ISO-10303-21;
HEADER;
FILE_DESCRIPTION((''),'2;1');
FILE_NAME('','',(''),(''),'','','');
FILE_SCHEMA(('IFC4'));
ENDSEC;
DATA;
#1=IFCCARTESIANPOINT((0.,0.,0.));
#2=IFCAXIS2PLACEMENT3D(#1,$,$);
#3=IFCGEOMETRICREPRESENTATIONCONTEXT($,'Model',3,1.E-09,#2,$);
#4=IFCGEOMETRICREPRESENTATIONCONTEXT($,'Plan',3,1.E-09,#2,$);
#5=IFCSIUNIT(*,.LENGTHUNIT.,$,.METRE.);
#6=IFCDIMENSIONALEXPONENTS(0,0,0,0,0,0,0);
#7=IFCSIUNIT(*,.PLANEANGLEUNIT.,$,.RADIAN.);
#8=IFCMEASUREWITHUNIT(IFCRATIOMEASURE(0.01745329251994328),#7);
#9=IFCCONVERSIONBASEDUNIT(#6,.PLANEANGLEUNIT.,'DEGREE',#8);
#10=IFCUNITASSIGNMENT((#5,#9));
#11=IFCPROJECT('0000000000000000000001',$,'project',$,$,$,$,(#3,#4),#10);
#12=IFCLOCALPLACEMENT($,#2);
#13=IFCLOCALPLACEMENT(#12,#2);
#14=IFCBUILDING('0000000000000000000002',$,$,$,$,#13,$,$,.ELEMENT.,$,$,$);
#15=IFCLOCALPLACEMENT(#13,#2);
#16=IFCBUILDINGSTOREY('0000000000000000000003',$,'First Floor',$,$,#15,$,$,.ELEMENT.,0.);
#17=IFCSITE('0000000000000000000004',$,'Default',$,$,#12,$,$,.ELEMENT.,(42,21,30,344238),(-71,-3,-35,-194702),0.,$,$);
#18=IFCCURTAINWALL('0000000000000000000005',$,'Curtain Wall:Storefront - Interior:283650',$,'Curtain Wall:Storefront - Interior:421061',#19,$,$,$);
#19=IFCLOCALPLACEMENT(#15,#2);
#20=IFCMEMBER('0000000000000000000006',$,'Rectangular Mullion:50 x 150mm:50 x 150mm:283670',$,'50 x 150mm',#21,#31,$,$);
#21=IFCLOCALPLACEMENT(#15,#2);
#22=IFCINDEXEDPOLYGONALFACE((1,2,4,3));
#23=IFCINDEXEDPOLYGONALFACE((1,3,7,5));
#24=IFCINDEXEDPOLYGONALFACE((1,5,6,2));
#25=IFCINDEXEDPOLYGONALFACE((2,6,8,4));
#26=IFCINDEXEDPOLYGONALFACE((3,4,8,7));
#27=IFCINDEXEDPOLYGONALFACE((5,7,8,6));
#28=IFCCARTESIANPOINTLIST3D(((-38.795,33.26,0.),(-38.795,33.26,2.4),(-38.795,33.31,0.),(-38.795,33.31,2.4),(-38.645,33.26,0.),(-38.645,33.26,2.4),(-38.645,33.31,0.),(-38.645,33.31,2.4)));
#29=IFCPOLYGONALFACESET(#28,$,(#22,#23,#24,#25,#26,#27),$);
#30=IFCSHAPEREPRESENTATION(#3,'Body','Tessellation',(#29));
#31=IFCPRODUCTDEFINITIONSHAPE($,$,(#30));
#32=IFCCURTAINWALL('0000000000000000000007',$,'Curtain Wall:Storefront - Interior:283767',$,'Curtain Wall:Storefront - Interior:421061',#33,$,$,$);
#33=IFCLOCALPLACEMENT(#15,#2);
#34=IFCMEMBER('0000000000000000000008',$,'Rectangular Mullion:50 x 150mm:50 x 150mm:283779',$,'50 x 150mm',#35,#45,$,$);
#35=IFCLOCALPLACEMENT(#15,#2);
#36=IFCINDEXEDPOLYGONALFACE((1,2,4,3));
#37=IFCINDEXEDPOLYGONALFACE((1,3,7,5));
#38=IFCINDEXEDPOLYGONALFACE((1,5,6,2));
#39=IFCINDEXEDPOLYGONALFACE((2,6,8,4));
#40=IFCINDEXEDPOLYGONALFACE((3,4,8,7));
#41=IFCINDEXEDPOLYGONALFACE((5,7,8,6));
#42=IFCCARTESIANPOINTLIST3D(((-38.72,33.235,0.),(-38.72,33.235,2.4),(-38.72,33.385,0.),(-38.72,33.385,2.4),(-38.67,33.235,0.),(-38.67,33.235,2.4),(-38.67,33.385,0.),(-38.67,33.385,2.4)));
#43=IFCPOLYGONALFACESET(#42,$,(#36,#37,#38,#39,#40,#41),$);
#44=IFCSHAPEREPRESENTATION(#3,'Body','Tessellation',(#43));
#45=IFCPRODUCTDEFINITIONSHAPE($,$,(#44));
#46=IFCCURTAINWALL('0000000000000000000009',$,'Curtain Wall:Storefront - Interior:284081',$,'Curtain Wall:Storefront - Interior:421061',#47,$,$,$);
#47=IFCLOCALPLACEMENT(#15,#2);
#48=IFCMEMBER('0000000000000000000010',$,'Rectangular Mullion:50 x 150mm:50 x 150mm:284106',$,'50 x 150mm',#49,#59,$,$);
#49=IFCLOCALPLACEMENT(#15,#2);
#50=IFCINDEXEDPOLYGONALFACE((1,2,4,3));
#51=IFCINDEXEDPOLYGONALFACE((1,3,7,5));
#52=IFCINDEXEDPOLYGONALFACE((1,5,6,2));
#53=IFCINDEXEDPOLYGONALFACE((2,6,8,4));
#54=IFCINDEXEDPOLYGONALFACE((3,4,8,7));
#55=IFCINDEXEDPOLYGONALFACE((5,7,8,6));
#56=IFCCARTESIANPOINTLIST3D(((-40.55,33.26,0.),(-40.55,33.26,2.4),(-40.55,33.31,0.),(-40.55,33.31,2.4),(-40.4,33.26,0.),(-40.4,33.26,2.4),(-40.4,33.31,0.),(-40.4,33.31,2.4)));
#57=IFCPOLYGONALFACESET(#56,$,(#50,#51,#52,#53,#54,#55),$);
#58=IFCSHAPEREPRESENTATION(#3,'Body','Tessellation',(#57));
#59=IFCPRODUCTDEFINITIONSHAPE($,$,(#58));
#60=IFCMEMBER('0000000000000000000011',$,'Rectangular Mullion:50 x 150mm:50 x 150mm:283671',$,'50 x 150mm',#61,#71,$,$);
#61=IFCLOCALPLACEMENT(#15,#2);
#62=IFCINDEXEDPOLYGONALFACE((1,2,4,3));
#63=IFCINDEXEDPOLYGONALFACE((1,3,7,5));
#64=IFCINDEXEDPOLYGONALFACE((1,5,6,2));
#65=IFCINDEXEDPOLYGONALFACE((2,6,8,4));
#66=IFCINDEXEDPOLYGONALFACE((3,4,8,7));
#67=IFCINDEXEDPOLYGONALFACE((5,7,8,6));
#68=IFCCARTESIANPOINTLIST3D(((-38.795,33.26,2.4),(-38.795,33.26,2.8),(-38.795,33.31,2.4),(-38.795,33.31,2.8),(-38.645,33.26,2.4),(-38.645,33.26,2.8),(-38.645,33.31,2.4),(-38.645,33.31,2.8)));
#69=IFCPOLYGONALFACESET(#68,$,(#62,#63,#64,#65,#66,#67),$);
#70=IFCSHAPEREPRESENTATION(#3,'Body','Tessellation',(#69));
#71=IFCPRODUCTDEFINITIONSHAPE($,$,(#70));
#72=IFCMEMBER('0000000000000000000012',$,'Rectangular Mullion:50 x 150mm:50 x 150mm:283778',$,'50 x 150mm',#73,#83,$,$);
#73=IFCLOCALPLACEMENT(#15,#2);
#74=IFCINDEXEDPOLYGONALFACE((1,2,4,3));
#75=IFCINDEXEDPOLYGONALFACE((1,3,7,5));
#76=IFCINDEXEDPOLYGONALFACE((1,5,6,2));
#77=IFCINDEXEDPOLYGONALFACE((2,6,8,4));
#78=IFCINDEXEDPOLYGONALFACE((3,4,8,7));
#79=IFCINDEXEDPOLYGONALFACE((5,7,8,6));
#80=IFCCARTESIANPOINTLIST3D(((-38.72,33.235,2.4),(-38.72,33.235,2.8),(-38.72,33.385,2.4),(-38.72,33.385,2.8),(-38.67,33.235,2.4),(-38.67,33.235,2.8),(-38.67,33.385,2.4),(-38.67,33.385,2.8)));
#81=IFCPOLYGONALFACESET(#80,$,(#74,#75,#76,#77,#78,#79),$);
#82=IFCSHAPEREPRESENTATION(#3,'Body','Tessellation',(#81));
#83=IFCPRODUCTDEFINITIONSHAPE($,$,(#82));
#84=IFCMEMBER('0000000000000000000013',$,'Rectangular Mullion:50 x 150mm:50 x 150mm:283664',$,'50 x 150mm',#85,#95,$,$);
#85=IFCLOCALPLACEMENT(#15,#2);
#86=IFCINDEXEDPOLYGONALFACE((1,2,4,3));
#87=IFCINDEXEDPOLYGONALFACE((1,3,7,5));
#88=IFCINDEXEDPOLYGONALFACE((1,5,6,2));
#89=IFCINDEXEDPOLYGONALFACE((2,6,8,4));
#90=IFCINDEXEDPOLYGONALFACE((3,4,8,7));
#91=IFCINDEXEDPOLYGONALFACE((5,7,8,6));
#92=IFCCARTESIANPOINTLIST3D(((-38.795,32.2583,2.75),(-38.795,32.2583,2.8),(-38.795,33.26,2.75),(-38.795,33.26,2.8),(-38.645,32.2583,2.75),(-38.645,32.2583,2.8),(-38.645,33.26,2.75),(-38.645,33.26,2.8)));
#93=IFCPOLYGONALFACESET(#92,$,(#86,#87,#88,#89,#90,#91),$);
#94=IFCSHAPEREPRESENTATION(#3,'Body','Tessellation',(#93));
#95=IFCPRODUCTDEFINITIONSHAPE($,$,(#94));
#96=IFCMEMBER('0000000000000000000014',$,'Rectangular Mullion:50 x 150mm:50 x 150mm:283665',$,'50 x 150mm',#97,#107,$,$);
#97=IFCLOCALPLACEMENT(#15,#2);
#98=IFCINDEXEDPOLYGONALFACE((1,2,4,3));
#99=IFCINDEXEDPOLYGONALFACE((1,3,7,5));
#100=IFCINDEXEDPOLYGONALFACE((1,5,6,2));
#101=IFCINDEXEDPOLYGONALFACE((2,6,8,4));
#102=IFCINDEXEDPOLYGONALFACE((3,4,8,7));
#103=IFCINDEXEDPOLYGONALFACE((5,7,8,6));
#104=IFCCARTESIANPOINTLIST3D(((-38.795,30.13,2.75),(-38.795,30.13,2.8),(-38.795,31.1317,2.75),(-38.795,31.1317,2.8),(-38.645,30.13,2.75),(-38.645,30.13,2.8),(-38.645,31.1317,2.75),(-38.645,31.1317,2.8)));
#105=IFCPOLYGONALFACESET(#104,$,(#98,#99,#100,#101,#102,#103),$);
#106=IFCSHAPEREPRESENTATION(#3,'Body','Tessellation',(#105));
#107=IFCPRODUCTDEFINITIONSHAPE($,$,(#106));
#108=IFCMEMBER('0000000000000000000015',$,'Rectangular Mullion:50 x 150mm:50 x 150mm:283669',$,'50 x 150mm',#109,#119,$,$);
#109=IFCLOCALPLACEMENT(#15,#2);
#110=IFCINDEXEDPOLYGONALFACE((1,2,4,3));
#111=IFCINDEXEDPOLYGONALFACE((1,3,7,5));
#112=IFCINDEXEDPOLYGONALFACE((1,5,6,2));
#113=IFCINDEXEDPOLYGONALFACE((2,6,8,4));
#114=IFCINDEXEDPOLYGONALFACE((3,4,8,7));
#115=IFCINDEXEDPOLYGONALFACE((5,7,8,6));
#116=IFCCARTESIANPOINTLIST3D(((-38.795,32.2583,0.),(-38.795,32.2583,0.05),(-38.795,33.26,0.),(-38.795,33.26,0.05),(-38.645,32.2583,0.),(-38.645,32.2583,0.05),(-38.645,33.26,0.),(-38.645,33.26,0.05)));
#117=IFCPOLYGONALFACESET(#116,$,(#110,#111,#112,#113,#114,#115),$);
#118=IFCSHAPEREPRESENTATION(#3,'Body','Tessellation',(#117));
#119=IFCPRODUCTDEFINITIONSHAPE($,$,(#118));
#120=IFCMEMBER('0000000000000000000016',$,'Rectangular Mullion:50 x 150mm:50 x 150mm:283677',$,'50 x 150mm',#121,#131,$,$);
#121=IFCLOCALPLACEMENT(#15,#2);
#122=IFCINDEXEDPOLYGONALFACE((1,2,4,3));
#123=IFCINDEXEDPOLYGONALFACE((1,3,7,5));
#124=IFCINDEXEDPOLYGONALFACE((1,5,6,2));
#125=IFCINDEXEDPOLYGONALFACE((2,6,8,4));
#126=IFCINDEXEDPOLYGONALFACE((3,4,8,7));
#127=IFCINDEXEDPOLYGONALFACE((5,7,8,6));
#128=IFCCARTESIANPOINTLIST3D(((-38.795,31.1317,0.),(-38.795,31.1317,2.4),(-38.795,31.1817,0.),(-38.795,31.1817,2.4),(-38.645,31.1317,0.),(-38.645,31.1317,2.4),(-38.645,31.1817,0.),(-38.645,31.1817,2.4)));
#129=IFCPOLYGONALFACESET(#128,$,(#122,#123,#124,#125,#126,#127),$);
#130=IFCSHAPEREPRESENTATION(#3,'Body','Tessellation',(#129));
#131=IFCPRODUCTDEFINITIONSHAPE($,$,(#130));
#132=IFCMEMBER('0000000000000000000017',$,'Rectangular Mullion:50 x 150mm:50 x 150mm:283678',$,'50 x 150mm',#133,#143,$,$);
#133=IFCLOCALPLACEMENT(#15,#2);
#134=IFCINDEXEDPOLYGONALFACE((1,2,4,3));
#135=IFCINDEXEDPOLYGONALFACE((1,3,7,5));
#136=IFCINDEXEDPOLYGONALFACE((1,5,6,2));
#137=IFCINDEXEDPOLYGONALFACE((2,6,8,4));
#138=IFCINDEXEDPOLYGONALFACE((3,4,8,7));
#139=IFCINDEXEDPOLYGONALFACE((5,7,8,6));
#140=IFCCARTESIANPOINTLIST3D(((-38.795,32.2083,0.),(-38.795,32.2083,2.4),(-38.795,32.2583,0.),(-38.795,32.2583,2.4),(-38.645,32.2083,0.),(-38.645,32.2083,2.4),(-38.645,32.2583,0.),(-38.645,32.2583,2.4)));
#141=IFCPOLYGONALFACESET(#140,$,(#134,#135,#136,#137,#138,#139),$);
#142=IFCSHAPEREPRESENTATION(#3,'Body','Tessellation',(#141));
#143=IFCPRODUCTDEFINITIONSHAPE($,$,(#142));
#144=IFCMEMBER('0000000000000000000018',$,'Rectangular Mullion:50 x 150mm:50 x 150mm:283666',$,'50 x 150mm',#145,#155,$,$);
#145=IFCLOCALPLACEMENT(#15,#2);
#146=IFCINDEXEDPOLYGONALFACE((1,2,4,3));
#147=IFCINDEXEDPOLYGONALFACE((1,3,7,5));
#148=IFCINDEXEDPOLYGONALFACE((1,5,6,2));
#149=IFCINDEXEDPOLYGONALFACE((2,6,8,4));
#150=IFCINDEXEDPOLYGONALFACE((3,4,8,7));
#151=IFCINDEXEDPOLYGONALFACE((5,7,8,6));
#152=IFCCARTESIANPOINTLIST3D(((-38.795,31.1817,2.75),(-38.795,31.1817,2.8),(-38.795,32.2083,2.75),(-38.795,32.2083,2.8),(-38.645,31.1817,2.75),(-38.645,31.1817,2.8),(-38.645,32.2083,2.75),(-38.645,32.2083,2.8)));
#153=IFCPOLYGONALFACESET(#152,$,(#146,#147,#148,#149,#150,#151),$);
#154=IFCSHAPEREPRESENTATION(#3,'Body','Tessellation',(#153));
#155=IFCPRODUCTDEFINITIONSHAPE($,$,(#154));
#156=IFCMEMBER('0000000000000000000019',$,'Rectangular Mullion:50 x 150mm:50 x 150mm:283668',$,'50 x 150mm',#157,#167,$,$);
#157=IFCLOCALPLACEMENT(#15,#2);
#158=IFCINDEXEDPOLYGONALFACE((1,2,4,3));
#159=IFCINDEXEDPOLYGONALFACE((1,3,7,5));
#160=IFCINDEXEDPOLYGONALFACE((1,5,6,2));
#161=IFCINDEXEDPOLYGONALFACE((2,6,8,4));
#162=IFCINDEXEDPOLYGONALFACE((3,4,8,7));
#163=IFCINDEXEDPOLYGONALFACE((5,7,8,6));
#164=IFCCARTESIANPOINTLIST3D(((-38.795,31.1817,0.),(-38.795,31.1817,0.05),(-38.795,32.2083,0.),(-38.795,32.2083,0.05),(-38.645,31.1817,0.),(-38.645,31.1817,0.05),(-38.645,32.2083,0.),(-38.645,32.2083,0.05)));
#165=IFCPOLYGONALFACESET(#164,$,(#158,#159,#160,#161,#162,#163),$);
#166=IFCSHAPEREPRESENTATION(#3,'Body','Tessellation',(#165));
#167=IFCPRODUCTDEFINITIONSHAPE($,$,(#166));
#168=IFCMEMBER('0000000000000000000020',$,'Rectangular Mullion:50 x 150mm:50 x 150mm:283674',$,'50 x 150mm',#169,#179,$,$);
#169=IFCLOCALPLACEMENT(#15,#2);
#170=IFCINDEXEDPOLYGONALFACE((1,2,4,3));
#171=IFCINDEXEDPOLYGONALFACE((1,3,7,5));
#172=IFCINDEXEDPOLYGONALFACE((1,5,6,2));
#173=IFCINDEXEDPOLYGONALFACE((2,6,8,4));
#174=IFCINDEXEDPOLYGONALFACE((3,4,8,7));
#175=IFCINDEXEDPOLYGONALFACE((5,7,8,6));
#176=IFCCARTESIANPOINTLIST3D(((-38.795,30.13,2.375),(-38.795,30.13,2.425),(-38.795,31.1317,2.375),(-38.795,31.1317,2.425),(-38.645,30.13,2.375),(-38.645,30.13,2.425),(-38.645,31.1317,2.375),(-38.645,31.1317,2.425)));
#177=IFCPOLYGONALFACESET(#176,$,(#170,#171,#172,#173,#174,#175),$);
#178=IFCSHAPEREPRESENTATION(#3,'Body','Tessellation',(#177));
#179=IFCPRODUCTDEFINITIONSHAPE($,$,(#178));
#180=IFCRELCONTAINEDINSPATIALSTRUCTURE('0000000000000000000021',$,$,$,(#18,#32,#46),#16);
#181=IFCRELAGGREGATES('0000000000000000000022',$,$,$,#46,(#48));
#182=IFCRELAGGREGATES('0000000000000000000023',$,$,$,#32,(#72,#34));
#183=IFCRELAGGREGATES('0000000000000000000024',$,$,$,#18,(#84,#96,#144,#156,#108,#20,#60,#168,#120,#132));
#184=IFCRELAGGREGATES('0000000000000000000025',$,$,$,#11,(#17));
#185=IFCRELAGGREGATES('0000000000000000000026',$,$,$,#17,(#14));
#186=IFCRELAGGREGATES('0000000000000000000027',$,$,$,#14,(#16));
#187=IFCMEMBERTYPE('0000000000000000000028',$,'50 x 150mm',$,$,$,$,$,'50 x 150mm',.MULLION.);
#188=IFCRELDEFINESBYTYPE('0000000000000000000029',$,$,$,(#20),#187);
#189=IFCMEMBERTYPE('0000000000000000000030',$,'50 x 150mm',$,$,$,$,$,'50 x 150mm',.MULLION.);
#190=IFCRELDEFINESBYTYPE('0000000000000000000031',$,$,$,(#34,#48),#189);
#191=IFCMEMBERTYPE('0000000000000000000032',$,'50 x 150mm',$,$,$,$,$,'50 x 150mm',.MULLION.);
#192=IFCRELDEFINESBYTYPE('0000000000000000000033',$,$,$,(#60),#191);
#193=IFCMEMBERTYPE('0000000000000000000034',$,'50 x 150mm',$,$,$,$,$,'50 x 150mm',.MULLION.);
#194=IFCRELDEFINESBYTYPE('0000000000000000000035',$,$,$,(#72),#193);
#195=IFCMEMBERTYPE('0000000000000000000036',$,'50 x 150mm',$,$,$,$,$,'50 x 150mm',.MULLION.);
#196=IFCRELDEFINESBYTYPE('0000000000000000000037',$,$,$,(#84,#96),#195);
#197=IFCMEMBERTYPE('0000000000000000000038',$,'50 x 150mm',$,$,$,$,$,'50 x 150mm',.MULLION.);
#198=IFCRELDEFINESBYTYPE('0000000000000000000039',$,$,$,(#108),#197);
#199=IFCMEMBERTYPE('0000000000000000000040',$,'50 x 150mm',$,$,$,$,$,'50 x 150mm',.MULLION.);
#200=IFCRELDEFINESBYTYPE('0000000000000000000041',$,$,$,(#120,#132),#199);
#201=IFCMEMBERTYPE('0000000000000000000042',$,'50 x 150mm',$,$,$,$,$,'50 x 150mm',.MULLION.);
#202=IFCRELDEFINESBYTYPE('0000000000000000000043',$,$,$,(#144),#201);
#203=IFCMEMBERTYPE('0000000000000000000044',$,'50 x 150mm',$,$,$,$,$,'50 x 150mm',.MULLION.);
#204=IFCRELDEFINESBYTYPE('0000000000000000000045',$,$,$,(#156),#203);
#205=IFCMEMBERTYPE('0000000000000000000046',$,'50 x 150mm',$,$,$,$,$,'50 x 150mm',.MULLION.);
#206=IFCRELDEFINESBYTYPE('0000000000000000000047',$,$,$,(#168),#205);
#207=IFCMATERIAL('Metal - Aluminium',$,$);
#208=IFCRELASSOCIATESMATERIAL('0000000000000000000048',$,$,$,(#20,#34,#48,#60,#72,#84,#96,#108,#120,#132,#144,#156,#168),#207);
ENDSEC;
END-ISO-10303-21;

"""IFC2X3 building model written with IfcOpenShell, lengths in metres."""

from ifc_helpers import new_model, entity, si_unit, converted_unit, frame, origin, origin_2d_with_axis, place, context, project, spatial, rectangle, extrude, source, transform, mapped, material, type_object, type_shapes, element, aggregate, save


model = new_model("IFC2X3")

# Units and contexts
model_context = context("Model", 3, precision=1e-09, world=origin())
plan_context = context("Plan", 3, precision=1e-09, world=origin())
ifc_project = project(units=[si_unit("LENGTHUNIT", "METRE"), converted_unit("PLANEANGLEUNIT", "DEGREE", entity("IfcRatioMeasure", 0.01745329251994328), si_unit("PLANEANGLEUNIT", "RADIAN"), dimensions=[0, 0, 0, 0, 0, 0, 0])], contexts=[model_context, plan_context])

# Site, building, storey
site_placement = place(None, origin())
site = spatial("IfcSite", under=ifc_project, at=site_placement, Name="Default", CompositionType="ELEMENT", RefLatitude=(42, 21, 30, 344238), RefLongitude=(-71, -3, -35, -194702), RefElevation=0.0)
building_placement = place(site_placement, origin())
building = spatial("IfcBuilding", under=site, at=building_placement, CompositionType="ELEMENT")
storey_placement = place(building_placement, origin())
storey = spatial("IfcBuildingStorey", under=building, at=storey_placement, Name="First Floor", CompositionType="ELEMENT", Elevation=0.0)

# Curtain walls, members
curtain_wall_1_placement = place(storey_placement, origin())
curtain_wall_1 = element("IfcCurtainWall", 1, at=curtain_wall_1_placement, inside=storey, Name="Curtain Wall:Storefront - Interior:283650", ObjectType="Curtain Wall:Storefront - Interior:421061")
ifc_material_1 = material(Name="Metal - Aluminium")
member_type_1 = type_object("IfcMemberType", Name="50 x 150mm", ElementType="50 x 150mm", PredefinedType="MULLION")
shared_shape_1 = source(origin(), model_context, "Body", "SweptSolid", [
    extrude(rectangle(XDim=0.05, YDim=0.15, at=origin_2d_with_axis()), frame((-0.025, 0.0, -2.4), z_axis=(0.0, 0.0, 1.0), x_axis=(-1.0, 0.0, 0.0)), (0.0, 0.0, 1.0), 2.4),
])
type_shapes(member_type_1, [shared_shape_1])
member_1_placement = place(storey_placement, frame((-38.72, 33.31, 0.0), z_axis=(0.0, 0.0, -1.0), x_axis=(0.0, 1.0, 0.0)))
member_1 = element("IfcMember", 2, at=member_1_placement, type_object=member_type_1, material=ifc_material_1, Name="Rectangular Mullion:50 x 150mm:50 x 150mm:283670", ObjectType="50 x 150mm", context=model_context, shape_type="MappedRepresentation", body=[
    mapped(shared_shape_1, transform((0.0, 0.0, 0.0), scale=1.0)),
])
curtain_wall_2_placement = place(storey_placement, origin())
curtain_wall_2 = element("IfcCurtainWall", 3, at=curtain_wall_2_placement, inside=storey, Name="Curtain Wall:Storefront - Interior:283767", ObjectType="Curtain Wall:Storefront - Interior:421061")
member_type_2 = type_object("IfcMemberType", Name="50 x 150mm", ElementType="50 x 150mm", PredefinedType="MULLION")
type_shapes(member_type_2, [shared_shape_1])
member_2_placement = place(storey_placement, frame((-38.72, 33.31, 2.4), z_axis=(0.0, 0.0, 1.0), x_axis=(-1.0, 0.0, 0.0)))
member_2 = element("IfcMember", 4, at=member_2_placement, type_object=member_type_2, material=ifc_material_1, Name="Rectangular Mullion:50 x 150mm:50 x 150mm:283779", ObjectType="50 x 150mm", context=model_context, shape_type="MappedRepresentation", body=[
    mapped(shared_shape_1, transform((0.0, 0.0, 0.0), scale=1.0)),
])
curtain_wall_3_placement = place(storey_placement, origin())
curtain_wall_3 = element("IfcCurtainWall", 5, at=curtain_wall_3_placement, inside=storey, Name="Curtain Wall:Storefront - Interior:284081", ObjectType="Curtain Wall:Storefront - Interior:421061")
member_3_placement = place(storey_placement, frame((-40.475, 33.31, 2.4), z_axis=(0.0, 0.0, 1.0), x_axis=(0.0, 1.0, 0.0)))
member_3 = element("IfcMember", 6, at=member_3_placement, type_object=member_type_2, material=ifc_material_1, Name="Rectangular Mullion:50 x 150mm:50 x 150mm:284106", ObjectType="50 x 150mm", context=model_context, shape_type="MappedRepresentation", body=[
    mapped(shared_shape_1, transform((0.0, 0.0, 0.0), scale=1.0)),
])
aggregate(curtain_wall_3, [member_3])

# Members
member_type_3 = type_object("IfcMemberType", Name="50 x 150mm", ElementType="50 x 150mm", PredefinedType="MULLION")
shared_shape_2 = source(origin(), model_context, "Body", "SweptSolid", [
    extrude(rectangle(XDim=0.05, YDim=0.15, at=origin_2d_with_axis()), frame((-0.025, 0.0, -0.4), z_axis=(0.0, 0.0, 1.0), x_axis=(-1.0, 0.0, 0.0)), (0.0, 0.0, 1.0), 0.4),
])
type_shapes(member_type_3, [shared_shape_2])
member_4_placement = place(storey_placement, frame((-38.72, 33.31, 2.4), z_axis=(0.0, 0.0, -1.0), x_axis=(0.0, 1.0, 0.0)))
member_4 = element("IfcMember", 7, at=member_4_placement, type_object=member_type_3, material=ifc_material_1, Name="Rectangular Mullion:50 x 150mm:50 x 150mm:283671", ObjectType="50 x 150mm", context=model_context, shape_type="MappedRepresentation", body=[
    mapped(shared_shape_2, transform((0.0, 0.0, 0.0), scale=1.0)),
])
member_type_4 = type_object("IfcMemberType", Name="50 x 150mm", ElementType="50 x 150mm", PredefinedType="MULLION")
type_shapes(member_type_4, [shared_shape_2])
member_5_placement = place(storey_placement, frame((-38.72, 33.31, 2.8), z_axis=(0.0, 0.0, 1.0), x_axis=(-1.0, 0.0, 0.0)))
member_5 = element("IfcMember", 8, at=member_5_placement, type_object=member_type_4, material=ifc_material_1, Name="Rectangular Mullion:50 x 150mm:50 x 150mm:283778", ObjectType="50 x 150mm", context=model_context, shape_type="MappedRepresentation", body=[
    mapped(shared_shape_2, transform((0.0, 0.0, 0.0), scale=1.0)),
])
member_type_5 = type_object("IfcMemberType", Name="50 x 150mm", ElementType="50 x 150mm", PredefinedType="MULLION")
shared_shape_3 = source(origin(), model_context, "Body", "SweptSolid", [
    extrude(rectangle(XDim=0.05, YDim=0.15, at=origin_2d_with_axis()), frame((-0.025, 0.0, -1.0017), z_axis=(0.0, 0.0, 1.0), x_axis=(-1.0, 0.0, 0.0)), (0.0, 0.0, 1.0), 1.0017),
])
type_shapes(member_type_5, [shared_shape_3])
member_6_placement = place(storey_placement, frame((-38.72, 33.26, 2.8), z_axis=(0.0, 1.0, 0.0), x_axis=(0.0, 0.0, 1.0)))
member_6 = element("IfcMember", 9, at=member_6_placement, type_object=member_type_5, material=ifc_material_1, Name="Rectangular Mullion:50 x 150mm:50 x 150mm:283664", ObjectType="50 x 150mm", context=model_context, shape_type="MappedRepresentation", body=[
    mapped(shared_shape_3, transform((0.0, 0.0, 0.0), scale=1.0)),
])
member_7_placement = place(storey_placement, frame((-38.72, 31.1317, 2.8), z_axis=(0.0, 1.0, 0.0), x_axis=(0.0, 0.0, 1.0)))
member_7 = element("IfcMember", 10, at=member_7_placement, type_object=member_type_5, material=ifc_material_1, Name="Rectangular Mullion:50 x 150mm:50 x 150mm:283665", ObjectType="50 x 150mm", context=model_context, shape_type="MappedRepresentation", body=[
    mapped(shared_shape_3, transform((0.0, 0.0, 0.0), scale=1.0)),
])
member_type_6 = type_object("IfcMemberType", Name="50 x 150mm", ElementType="50 x 150mm", PredefinedType="MULLION")
type_shapes(member_type_6, [shared_shape_3])
member_8_placement = place(storey_placement, frame((-38.72, 32.2583, 0.0), z_axis=(0.0, -1.0, 0.0), x_axis=(0.0, 0.0, -1.0)))
member_8 = element("IfcMember", 11, at=member_8_placement, type_object=member_type_6, material=ifc_material_1, Name="Rectangular Mullion:50 x 150mm:50 x 150mm:283669", ObjectType="50 x 150mm", context=model_context, shape_type="MappedRepresentation", body=[
    mapped(shared_shape_3, transform((0.0, 0.0, 0.0), scale=1.0)),
])
member_type_7 = type_object("IfcMemberType", Name="50 x 150mm", ElementType="50 x 150mm", PredefinedType="MULLION")
shared_shape_4 = source(origin(), model_context, "Body", "SweptSolid", [
    extrude(rectangle(XDim=0.05, YDim=0.15, at=origin_2d_with_axis()), frame((0.0, 0.0, -2.4), z_axis=(0.0, 0.0, 1.0), x_axis=(-1.0, 0.0, 0.0)), (0.0, 0.0, 1.0), 2.4),
])
type_shapes(member_type_7, [shared_shape_4])
member_9_placement = place(storey_placement, frame((-38.72, 31.1567, 0.0), z_axis=(0.0, 0.0, -1.0), x_axis=(0.0, 1.0, 0.0)))
member_9 = element("IfcMember", 12, at=member_9_placement, type_object=member_type_7, material=ifc_material_1, Name="Rectangular Mullion:50 x 150mm:50 x 150mm:283677", ObjectType="50 x 150mm", context=model_context, shape_type="MappedRepresentation", body=[
    mapped(shared_shape_4, transform((0.0, 0.0, 0.0), scale=1.0)),
])
member_10_placement = place(storey_placement, frame((-38.72, 32.2333, 0.0), z_axis=(0.0, 0.0, -1.0), x_axis=(0.0, 1.0, 0.0)))
member_10 = element("IfcMember", 13, at=member_10_placement, type_object=member_type_7, material=ifc_material_1, Name="Rectangular Mullion:50 x 150mm:50 x 150mm:283678", ObjectType="50 x 150mm", context=model_context, shape_type="MappedRepresentation", body=[
    mapped(shared_shape_4, transform((0.0, 0.0, 0.0), scale=1.0)),
])
member_type_8 = type_object("IfcMemberType", Name="50 x 150mm", ElementType="50 x 150mm", PredefinedType="MULLION")
shared_shape_5 = source(origin(), model_context, "Body", "SweptSolid", [
    extrude(rectangle(XDim=0.05, YDim=0.15, at=origin_2d_with_axis()), frame((-0.025, 0.0, -1.0267), z_axis=(0.0, 0.0, 1.0), x_axis=(-1.0, 0.0, 0.0)), (0.0, 0.0, 1.0), 1.0267),
])
type_shapes(member_type_8, [shared_shape_5])
member_11_placement = place(storey_placement, frame((-38.72, 32.2083, 2.8), z_axis=(0.0, 1.0, 0.0), x_axis=(0.0, 0.0, 1.0)))
member_11 = element("IfcMember", 14, at=member_11_placement, type_object=member_type_8, material=ifc_material_1, Name="Rectangular Mullion:50 x 150mm:50 x 150mm:283666", ObjectType="50 x 150mm", context=model_context, shape_type="MappedRepresentation", body=[
    mapped(shared_shape_5, transform((0.0, 0.0, 0.0), scale=1.0)),
])
member_type_9 = type_object("IfcMemberType", Name="50 x 150mm", ElementType="50 x 150mm", PredefinedType="MULLION")
type_shapes(member_type_9, [shared_shape_5])
member_12_placement = place(storey_placement, frame((-38.72, 31.1817, 0.0), z_axis=(0.0, -1.0, 0.0), x_axis=(0.0, 0.0, -1.0)))
member_12 = element("IfcMember", 15, at=member_12_placement, type_object=member_type_9, material=ifc_material_1, Name="Rectangular Mullion:50 x 150mm:50 x 150mm:283668", ObjectType="50 x 150mm", context=model_context, shape_type="MappedRepresentation", body=[
    mapped(shared_shape_5, transform((0.0, 0.0, 0.0), scale=1.0)),
])
member_type_10 = type_object("IfcMemberType", Name="50 x 150mm", ElementType="50 x 150mm", PredefinedType="MULLION")
shared_shape_6 = source(origin(), model_context, "Body", "SweptSolid", [
    extrude(rectangle(XDim=0.05, YDim=0.15, at=origin_2d_with_axis()), frame((0.0, 0.0, -1.0017), z_axis=(0.0, 0.0, 1.0), x_axis=(-1.0, 0.0, 0.0)), (0.0, 0.0, 1.0), 1.0017),
])
type_shapes(member_type_10, [shared_shape_6])
member_13_placement = place(storey_placement, frame((-38.72, 31.1317, 2.4), z_axis=(0.0, 1.0, 0.0), x_axis=(0.0, 0.0, 1.0)))
member_13 = element("IfcMember", 16, at=member_13_placement, type_object=member_type_10, material=ifc_material_1, Name="Rectangular Mullion:50 x 150mm:50 x 150mm:283674", ObjectType="50 x 150mm", context=model_context, shape_type="MappedRepresentation", body=[
    mapped(shared_shape_6, transform((0.0, 0.0, 0.0), scale=1.0)),
])
aggregate(curtain_wall_2, [member_5, member_2])

aggregate(curtain_wall_1, [member_6, member_7, member_11, member_12, member_8, member_1, member_4, member_13, member_9, member_10])

save(model, "model.ifc")
